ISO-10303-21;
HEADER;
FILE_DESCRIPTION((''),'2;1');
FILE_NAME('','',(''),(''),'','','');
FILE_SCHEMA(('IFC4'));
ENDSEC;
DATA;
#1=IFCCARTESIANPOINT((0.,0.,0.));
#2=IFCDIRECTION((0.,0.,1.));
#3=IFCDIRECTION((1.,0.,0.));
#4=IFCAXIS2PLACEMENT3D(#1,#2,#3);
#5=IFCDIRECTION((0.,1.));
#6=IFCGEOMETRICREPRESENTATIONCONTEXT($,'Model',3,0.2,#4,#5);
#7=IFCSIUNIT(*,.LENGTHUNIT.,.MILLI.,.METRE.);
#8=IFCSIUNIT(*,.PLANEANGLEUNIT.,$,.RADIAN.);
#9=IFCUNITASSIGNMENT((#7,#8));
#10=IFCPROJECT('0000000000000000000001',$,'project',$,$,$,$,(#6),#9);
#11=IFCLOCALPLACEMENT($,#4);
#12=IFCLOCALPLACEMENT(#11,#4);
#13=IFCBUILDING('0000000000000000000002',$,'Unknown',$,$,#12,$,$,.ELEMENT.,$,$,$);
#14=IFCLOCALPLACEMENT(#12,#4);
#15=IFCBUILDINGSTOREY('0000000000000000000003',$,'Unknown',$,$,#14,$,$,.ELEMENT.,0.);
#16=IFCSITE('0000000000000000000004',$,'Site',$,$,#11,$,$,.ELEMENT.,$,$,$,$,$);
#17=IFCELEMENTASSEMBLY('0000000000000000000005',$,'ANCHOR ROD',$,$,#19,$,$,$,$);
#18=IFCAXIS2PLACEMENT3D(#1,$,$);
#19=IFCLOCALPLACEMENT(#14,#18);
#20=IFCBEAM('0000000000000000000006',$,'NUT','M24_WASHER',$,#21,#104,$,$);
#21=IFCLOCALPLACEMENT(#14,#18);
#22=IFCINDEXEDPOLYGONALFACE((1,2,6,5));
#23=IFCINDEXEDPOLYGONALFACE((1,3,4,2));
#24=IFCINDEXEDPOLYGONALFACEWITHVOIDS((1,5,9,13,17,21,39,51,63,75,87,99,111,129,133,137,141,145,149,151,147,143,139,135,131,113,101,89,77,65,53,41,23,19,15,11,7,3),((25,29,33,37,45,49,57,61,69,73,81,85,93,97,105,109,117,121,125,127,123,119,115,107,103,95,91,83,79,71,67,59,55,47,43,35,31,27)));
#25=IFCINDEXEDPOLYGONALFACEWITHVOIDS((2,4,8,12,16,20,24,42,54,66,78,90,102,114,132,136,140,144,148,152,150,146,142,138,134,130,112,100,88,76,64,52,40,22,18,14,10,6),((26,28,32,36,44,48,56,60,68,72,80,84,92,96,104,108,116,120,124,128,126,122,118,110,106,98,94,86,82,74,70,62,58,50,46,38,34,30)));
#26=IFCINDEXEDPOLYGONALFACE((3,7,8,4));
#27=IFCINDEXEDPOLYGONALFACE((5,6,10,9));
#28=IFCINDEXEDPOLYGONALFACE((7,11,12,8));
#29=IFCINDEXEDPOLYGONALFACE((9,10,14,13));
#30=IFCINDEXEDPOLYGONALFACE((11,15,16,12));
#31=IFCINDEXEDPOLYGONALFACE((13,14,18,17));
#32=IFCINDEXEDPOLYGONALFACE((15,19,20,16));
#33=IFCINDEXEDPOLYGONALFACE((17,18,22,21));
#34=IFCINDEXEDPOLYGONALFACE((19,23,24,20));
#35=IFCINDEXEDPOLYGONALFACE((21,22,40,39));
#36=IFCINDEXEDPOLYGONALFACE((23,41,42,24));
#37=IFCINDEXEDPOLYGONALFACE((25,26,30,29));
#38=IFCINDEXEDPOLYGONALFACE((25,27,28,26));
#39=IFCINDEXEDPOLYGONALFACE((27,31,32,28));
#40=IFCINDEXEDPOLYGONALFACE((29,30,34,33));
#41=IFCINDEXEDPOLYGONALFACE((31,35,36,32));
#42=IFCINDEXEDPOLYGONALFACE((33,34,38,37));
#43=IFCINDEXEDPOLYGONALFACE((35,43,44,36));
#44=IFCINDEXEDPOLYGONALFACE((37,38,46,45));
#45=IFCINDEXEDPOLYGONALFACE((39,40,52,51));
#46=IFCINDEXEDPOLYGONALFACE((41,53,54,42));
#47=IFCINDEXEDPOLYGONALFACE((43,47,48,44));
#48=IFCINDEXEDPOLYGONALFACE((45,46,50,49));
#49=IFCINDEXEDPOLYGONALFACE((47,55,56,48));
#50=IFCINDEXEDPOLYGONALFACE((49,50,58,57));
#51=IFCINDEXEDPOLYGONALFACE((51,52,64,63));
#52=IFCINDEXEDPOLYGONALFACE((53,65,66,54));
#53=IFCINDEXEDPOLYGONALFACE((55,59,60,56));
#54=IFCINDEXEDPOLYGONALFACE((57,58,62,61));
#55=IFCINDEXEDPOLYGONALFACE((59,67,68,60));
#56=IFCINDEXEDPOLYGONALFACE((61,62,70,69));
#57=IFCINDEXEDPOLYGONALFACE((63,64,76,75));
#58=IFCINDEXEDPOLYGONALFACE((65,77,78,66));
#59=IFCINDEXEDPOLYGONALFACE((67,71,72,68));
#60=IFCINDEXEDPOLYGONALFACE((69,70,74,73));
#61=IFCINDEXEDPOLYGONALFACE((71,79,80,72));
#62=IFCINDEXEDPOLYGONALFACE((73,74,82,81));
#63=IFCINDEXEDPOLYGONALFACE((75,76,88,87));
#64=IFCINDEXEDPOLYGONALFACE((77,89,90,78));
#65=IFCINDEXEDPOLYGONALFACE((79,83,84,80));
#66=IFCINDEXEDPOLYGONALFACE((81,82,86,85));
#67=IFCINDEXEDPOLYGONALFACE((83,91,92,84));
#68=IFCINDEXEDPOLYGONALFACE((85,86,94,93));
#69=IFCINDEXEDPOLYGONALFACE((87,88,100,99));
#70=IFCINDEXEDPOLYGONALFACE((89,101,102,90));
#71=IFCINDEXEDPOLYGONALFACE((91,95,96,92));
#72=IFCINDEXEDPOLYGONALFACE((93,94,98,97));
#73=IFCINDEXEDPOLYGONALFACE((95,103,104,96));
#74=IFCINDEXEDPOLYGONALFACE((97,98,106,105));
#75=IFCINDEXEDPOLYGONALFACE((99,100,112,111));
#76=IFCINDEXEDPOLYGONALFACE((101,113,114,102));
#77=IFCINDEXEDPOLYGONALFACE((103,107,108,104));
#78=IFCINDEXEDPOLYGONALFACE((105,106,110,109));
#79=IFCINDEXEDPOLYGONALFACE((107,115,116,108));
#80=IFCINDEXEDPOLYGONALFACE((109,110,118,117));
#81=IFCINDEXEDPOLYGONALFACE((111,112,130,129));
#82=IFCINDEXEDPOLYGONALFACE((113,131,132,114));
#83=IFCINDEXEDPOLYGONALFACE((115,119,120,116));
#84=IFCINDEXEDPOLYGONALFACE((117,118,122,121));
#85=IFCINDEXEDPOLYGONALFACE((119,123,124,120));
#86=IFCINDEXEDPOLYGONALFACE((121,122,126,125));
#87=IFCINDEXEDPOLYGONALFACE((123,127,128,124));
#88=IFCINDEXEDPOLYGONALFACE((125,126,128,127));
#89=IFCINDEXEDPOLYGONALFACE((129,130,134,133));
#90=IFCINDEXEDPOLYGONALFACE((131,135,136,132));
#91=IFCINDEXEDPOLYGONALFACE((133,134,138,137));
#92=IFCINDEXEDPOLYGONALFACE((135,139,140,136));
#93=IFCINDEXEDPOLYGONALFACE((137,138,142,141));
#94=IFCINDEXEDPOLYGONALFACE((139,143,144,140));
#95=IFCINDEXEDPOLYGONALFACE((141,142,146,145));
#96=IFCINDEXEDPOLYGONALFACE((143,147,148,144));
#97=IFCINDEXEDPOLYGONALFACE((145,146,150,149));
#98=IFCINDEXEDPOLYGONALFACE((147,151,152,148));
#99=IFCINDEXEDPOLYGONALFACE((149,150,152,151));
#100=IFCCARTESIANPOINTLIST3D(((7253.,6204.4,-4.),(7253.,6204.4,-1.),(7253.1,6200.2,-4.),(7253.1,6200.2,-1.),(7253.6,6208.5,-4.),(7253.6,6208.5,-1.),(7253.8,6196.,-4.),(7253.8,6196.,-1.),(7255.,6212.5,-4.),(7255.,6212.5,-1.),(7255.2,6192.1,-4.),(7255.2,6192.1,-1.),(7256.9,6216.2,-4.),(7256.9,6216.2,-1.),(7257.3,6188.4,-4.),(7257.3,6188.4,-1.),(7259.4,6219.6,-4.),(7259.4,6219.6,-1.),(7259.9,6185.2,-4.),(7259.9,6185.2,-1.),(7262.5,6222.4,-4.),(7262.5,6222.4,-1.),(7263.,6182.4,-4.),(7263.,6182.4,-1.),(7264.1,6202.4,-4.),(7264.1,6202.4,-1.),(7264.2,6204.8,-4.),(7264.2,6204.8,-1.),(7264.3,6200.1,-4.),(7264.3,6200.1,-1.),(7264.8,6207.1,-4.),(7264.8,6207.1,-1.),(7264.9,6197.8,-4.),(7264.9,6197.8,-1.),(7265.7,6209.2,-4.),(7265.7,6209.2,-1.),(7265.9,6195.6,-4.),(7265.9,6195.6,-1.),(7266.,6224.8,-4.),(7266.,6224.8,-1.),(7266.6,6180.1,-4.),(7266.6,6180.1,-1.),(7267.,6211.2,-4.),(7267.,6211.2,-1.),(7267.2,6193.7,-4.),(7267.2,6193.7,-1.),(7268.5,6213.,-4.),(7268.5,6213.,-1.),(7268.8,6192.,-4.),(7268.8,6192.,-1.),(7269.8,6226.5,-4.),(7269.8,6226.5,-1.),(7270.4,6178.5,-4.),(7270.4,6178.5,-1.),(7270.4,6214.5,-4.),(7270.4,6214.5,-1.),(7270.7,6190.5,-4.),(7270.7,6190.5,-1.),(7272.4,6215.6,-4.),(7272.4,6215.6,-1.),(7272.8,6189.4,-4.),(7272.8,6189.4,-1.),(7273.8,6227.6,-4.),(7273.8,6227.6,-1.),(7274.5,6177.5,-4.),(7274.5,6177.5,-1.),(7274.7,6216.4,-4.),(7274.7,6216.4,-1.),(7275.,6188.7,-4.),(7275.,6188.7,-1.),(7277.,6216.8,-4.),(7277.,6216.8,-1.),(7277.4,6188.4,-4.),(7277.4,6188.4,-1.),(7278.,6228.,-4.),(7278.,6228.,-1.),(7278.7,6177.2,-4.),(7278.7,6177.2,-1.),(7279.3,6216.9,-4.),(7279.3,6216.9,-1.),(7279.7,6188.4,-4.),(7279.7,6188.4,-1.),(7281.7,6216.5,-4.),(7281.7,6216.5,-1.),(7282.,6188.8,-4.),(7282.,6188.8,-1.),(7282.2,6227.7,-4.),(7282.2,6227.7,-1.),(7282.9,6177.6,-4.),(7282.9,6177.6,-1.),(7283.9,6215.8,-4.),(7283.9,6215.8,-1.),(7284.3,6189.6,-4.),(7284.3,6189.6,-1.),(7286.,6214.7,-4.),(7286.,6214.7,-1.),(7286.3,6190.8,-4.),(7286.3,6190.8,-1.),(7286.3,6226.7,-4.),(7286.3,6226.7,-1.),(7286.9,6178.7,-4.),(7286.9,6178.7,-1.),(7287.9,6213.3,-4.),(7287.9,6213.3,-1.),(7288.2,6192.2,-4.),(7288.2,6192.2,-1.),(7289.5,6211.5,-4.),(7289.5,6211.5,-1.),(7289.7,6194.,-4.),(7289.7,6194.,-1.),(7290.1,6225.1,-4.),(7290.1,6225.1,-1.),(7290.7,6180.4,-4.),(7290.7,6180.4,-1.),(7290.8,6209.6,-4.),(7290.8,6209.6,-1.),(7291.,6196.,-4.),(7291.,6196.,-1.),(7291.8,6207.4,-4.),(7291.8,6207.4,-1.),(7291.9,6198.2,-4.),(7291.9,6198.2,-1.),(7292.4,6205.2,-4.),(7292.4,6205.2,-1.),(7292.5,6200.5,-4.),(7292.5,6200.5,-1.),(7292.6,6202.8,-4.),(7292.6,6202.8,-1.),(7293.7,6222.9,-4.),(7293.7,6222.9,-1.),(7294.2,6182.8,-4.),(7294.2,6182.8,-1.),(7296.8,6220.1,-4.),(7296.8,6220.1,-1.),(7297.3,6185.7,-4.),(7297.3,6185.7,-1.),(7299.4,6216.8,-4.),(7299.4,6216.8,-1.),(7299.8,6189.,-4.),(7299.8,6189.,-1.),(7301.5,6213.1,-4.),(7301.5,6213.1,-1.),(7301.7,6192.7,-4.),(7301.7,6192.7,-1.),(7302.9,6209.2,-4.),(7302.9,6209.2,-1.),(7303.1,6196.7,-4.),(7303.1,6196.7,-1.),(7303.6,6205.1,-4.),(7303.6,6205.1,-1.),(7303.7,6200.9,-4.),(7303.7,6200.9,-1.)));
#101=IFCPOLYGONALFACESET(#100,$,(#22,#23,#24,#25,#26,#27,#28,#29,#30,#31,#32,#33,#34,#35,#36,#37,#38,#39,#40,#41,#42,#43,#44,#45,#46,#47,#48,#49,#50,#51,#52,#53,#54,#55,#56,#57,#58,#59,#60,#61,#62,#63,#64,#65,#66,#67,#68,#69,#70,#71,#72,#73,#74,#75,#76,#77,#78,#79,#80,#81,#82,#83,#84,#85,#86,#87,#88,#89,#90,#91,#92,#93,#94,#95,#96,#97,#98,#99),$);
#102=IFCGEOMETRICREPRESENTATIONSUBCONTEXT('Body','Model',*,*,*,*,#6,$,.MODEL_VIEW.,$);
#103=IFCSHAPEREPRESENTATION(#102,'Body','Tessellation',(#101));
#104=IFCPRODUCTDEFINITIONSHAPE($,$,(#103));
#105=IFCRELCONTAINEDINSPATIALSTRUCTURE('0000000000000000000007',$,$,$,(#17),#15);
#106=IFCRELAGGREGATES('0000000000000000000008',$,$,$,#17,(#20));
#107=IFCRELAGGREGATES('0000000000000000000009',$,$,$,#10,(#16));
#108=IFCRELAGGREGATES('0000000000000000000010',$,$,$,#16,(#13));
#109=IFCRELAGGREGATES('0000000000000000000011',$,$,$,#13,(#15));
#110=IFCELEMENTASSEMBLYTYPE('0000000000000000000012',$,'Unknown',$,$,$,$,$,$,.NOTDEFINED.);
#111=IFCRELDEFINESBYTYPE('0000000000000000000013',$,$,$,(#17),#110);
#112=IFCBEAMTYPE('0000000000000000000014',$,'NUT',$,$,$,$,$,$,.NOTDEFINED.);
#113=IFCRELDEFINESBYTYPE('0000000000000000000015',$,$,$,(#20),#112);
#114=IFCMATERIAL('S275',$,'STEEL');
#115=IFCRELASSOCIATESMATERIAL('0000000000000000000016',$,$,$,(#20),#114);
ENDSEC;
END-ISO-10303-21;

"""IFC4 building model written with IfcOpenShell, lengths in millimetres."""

from ifc_helpers import new_model, si_unit, direction, frame, origin_with_axes, place, context, subcontext, project, spatial, polyline, outline, extrude, material, material_profile, profile_set, profile_usage, type_object, element, aggregate, save


model = new_model("IFC4")

# Units and contexts
model_context = context("Model", 3, precision=0.2, world=origin_with_axes(), true_north=direction((0.0, 1.0)))
body_context = subcontext(model_context, "Body", "Model", "MODEL_VIEW")
ifc_project = project(units=[si_unit("LENGTHUNIT", "METRE", prefix="MILLI"), si_unit("PLANEANGLEUNIT", "RADIAN")], contexts=[model_context])

# Site, building, storey
site_placement = place(None, origin_with_axes())
site = spatial("IfcSite", under=ifc_project, at=site_placement, Name="Site", CompositionType="ELEMENT")
building_placement = place(site_placement, origin_with_axes())
building = spatial("IfcBuilding", under=site, at=building_placement, Name="Unknown", CompositionType="ELEMENT")
storey_placement = place(building_placement, origin_with_axes())
storey = spatial("IfcBuildingStorey", under=building, at=storey_placement, Name="Unknown", CompositionType="ELEMENT", Elevation=0.0)

# Element assembly, beam
element_assembly_type = type_object("IfcElementAssemblyType", Name="Unknown", PredefinedType="NOTDEFINED")
assembly_1_placement = place(storey_placement, frame((7278.4, 6202.6, 39.0), z_axis=(0.154417, 0.988006, 0.0), x_axis=(0.0, 0.0, -1.0)))
assembly_1 = element("IfcElementAssembly", 1, at=assembly_1_placement, inside=storey, type_object=element_assembly_type, Name="ANCHOR ROD")
ifc_material_1 = material(Name="S275", Category="STEEL")
ifc_material_profile_1 = material_profile(ifc_material_1, outline(polyline([(25.4, 0.0), (25.1, 4.2), (24.0, 8.2), (22.3, 12.1), (20.0, 15.6), (17.2, 18.7), (13.9, 21.3), (10.2, 23.3), (6.2, 24.6), (2.1, 25.3), (-2.1, 25.3), (-6.2, 24.6), (-10.2, 23.3), (-13.9, 21.3), (-17.2, 18.7), (-20.0, 15.6), (-22.3, 12.1), (-24.0, 8.2), (-25.1, 4.2), (-25.4, 0.0), (-25.1, -4.2), (-24.0, -8.2), (-22.3, -12.1), (-20.0, -15.6), (-17.2, -18.7), (-13.9, -21.3), (-10.2, -23.3), (-6.2, -24.6), (-2.1, -25.3), (2.1, -25.3), (6.2, -24.6), (10.2, -23.3), (13.9, -21.3), (17.2, -18.7), (20.0, -15.6), (22.3, -12.1), (24.0, -8.2), (25.1, -4.2), (25.4, 0.0)]), holes=[polyline([(0.0, 14.3), (2.4, 14.1), (4.6, 13.5), (6.8, 12.6), (8.8, 11.3), (10.5, 9.7), (12.0, 7.8), (13.1, 5.7), (13.9, 3.5), (14.2, 1.2), (14.2, -1.2), (13.9, -3.5), (13.1, -5.7), (12.0, -7.8), (10.5, -9.7), (8.8, -11.3), (6.8, -12.6), (4.6, -13.5), (2.4, -14.1), (0.0, -14.3), (-2.4, -14.1), (-4.6, -13.5), (-6.8, -12.6), (-8.8, -11.3), (-10.5, -9.7), (-12.0, -7.8), (-13.1, -5.7), (-13.9, -3.5), (-14.2, -1.2), (-14.2, 1.2), (-13.9, 3.5), (-13.1, 5.7), (-12.0, 7.8), (-10.5, 9.7), (-8.8, 11.3), (-6.8, 12.6), (-4.6, 13.5), (-2.4, 14.1), (0.0, 14.3)])]), Name="M24_WASHER")
ifc_profile_set_1 = profile_set([ifc_material_profile_1])
ifc_profile_usage_1 = profile_usage(ifc_profile_set_1, cardinal=5)
beam_type_1 = type_object("IfcBeamType", Name="NUT", PredefinedType="NOTDEFINED")
beam_1_placement = place(assembly_1_placement, frame((40.0, 0.0, 0.0), z_axis=(0.0, 0.003454, 0.999994), x_axis=(1.0, 0.0, 0.0)))
beam_1 = element("IfcBeam", 2, at=beam_1_placement, type_object=beam_type_1, material=ifc_profile_usage_1, Name="NUT", Description="M24_WASHER", context=body_context, shape_type="SolidModel", body=[
    extrude(outline(polyline([(25.4, 0.0), (25.1, 4.2), (24.0, 8.2), (22.3, 12.1), (20.0, 15.6), (17.2, 18.7), (13.9, 21.3), (10.2, 23.3), (6.2, 24.6), (2.1, 25.3), (-2.1, 25.3), (-6.2, 24.6), (-10.2, 23.3), (-13.9, 21.3), (-17.2, 18.7), (-20.0, 15.6), (-22.3, 12.1), (-24.0, 8.2), (-25.1, 4.2), (-25.4, 0.0), (-25.1, -4.2), (-24.0, -8.2), (-22.3, -12.1), (-20.0, -15.6), (-17.2, -18.7), (-13.9, -21.3), (-10.2, -23.3), (-6.2, -24.6), (-2.1, -25.3), (2.1, -25.3), (6.2, -24.6), (10.2, -23.3), (13.9, -21.3), (17.2, -18.7), (20.0, -15.6), (22.3, -12.1), (24.0, -8.2), (25.1, -4.2), (25.4, 0.0)]), holes=[polyline([(0.0, 14.3), (2.4, 14.1), (4.6, 13.5), (6.8, 12.6), (8.8, 11.3), (10.5, 9.7), (12.0, 7.8), (13.1, 5.7), (13.9, 3.5), (14.2, 1.2), (14.2, -1.2), (13.9, -3.5), (13.1, -5.7), (12.0, -7.8), (10.5, -9.7), (8.8, -11.3), (6.8, -12.6), (4.6, -13.5), (2.4, -14.1), (0.0, -14.3), (-2.4, -14.1), (-4.6, -13.5), (-6.8, -12.6), (-8.8, -11.3), (-10.5, -9.7), (-12.0, -7.8), (-13.1, -5.7), (-13.9, -3.5), (-14.2, -1.2), (-14.2, 1.2), (-13.9, 3.5), (-13.1, 5.7), (-12.0, 7.8), (-10.5, 9.7), (-8.8, 11.3), (-6.8, 12.6), (-4.6, 13.5), (-2.4, 14.1), (0.0, 14.3)])]), frame((0.0, 0.0, 0.0), z_axis=(-1.0, 0.0, 0.0), x_axis=(0.0, 0.0, 1.0)), (0.0, 0.0, -1.0), 3.0),
])

aggregate(assembly_1, [beam_1])

save(model, "model.ifc")
